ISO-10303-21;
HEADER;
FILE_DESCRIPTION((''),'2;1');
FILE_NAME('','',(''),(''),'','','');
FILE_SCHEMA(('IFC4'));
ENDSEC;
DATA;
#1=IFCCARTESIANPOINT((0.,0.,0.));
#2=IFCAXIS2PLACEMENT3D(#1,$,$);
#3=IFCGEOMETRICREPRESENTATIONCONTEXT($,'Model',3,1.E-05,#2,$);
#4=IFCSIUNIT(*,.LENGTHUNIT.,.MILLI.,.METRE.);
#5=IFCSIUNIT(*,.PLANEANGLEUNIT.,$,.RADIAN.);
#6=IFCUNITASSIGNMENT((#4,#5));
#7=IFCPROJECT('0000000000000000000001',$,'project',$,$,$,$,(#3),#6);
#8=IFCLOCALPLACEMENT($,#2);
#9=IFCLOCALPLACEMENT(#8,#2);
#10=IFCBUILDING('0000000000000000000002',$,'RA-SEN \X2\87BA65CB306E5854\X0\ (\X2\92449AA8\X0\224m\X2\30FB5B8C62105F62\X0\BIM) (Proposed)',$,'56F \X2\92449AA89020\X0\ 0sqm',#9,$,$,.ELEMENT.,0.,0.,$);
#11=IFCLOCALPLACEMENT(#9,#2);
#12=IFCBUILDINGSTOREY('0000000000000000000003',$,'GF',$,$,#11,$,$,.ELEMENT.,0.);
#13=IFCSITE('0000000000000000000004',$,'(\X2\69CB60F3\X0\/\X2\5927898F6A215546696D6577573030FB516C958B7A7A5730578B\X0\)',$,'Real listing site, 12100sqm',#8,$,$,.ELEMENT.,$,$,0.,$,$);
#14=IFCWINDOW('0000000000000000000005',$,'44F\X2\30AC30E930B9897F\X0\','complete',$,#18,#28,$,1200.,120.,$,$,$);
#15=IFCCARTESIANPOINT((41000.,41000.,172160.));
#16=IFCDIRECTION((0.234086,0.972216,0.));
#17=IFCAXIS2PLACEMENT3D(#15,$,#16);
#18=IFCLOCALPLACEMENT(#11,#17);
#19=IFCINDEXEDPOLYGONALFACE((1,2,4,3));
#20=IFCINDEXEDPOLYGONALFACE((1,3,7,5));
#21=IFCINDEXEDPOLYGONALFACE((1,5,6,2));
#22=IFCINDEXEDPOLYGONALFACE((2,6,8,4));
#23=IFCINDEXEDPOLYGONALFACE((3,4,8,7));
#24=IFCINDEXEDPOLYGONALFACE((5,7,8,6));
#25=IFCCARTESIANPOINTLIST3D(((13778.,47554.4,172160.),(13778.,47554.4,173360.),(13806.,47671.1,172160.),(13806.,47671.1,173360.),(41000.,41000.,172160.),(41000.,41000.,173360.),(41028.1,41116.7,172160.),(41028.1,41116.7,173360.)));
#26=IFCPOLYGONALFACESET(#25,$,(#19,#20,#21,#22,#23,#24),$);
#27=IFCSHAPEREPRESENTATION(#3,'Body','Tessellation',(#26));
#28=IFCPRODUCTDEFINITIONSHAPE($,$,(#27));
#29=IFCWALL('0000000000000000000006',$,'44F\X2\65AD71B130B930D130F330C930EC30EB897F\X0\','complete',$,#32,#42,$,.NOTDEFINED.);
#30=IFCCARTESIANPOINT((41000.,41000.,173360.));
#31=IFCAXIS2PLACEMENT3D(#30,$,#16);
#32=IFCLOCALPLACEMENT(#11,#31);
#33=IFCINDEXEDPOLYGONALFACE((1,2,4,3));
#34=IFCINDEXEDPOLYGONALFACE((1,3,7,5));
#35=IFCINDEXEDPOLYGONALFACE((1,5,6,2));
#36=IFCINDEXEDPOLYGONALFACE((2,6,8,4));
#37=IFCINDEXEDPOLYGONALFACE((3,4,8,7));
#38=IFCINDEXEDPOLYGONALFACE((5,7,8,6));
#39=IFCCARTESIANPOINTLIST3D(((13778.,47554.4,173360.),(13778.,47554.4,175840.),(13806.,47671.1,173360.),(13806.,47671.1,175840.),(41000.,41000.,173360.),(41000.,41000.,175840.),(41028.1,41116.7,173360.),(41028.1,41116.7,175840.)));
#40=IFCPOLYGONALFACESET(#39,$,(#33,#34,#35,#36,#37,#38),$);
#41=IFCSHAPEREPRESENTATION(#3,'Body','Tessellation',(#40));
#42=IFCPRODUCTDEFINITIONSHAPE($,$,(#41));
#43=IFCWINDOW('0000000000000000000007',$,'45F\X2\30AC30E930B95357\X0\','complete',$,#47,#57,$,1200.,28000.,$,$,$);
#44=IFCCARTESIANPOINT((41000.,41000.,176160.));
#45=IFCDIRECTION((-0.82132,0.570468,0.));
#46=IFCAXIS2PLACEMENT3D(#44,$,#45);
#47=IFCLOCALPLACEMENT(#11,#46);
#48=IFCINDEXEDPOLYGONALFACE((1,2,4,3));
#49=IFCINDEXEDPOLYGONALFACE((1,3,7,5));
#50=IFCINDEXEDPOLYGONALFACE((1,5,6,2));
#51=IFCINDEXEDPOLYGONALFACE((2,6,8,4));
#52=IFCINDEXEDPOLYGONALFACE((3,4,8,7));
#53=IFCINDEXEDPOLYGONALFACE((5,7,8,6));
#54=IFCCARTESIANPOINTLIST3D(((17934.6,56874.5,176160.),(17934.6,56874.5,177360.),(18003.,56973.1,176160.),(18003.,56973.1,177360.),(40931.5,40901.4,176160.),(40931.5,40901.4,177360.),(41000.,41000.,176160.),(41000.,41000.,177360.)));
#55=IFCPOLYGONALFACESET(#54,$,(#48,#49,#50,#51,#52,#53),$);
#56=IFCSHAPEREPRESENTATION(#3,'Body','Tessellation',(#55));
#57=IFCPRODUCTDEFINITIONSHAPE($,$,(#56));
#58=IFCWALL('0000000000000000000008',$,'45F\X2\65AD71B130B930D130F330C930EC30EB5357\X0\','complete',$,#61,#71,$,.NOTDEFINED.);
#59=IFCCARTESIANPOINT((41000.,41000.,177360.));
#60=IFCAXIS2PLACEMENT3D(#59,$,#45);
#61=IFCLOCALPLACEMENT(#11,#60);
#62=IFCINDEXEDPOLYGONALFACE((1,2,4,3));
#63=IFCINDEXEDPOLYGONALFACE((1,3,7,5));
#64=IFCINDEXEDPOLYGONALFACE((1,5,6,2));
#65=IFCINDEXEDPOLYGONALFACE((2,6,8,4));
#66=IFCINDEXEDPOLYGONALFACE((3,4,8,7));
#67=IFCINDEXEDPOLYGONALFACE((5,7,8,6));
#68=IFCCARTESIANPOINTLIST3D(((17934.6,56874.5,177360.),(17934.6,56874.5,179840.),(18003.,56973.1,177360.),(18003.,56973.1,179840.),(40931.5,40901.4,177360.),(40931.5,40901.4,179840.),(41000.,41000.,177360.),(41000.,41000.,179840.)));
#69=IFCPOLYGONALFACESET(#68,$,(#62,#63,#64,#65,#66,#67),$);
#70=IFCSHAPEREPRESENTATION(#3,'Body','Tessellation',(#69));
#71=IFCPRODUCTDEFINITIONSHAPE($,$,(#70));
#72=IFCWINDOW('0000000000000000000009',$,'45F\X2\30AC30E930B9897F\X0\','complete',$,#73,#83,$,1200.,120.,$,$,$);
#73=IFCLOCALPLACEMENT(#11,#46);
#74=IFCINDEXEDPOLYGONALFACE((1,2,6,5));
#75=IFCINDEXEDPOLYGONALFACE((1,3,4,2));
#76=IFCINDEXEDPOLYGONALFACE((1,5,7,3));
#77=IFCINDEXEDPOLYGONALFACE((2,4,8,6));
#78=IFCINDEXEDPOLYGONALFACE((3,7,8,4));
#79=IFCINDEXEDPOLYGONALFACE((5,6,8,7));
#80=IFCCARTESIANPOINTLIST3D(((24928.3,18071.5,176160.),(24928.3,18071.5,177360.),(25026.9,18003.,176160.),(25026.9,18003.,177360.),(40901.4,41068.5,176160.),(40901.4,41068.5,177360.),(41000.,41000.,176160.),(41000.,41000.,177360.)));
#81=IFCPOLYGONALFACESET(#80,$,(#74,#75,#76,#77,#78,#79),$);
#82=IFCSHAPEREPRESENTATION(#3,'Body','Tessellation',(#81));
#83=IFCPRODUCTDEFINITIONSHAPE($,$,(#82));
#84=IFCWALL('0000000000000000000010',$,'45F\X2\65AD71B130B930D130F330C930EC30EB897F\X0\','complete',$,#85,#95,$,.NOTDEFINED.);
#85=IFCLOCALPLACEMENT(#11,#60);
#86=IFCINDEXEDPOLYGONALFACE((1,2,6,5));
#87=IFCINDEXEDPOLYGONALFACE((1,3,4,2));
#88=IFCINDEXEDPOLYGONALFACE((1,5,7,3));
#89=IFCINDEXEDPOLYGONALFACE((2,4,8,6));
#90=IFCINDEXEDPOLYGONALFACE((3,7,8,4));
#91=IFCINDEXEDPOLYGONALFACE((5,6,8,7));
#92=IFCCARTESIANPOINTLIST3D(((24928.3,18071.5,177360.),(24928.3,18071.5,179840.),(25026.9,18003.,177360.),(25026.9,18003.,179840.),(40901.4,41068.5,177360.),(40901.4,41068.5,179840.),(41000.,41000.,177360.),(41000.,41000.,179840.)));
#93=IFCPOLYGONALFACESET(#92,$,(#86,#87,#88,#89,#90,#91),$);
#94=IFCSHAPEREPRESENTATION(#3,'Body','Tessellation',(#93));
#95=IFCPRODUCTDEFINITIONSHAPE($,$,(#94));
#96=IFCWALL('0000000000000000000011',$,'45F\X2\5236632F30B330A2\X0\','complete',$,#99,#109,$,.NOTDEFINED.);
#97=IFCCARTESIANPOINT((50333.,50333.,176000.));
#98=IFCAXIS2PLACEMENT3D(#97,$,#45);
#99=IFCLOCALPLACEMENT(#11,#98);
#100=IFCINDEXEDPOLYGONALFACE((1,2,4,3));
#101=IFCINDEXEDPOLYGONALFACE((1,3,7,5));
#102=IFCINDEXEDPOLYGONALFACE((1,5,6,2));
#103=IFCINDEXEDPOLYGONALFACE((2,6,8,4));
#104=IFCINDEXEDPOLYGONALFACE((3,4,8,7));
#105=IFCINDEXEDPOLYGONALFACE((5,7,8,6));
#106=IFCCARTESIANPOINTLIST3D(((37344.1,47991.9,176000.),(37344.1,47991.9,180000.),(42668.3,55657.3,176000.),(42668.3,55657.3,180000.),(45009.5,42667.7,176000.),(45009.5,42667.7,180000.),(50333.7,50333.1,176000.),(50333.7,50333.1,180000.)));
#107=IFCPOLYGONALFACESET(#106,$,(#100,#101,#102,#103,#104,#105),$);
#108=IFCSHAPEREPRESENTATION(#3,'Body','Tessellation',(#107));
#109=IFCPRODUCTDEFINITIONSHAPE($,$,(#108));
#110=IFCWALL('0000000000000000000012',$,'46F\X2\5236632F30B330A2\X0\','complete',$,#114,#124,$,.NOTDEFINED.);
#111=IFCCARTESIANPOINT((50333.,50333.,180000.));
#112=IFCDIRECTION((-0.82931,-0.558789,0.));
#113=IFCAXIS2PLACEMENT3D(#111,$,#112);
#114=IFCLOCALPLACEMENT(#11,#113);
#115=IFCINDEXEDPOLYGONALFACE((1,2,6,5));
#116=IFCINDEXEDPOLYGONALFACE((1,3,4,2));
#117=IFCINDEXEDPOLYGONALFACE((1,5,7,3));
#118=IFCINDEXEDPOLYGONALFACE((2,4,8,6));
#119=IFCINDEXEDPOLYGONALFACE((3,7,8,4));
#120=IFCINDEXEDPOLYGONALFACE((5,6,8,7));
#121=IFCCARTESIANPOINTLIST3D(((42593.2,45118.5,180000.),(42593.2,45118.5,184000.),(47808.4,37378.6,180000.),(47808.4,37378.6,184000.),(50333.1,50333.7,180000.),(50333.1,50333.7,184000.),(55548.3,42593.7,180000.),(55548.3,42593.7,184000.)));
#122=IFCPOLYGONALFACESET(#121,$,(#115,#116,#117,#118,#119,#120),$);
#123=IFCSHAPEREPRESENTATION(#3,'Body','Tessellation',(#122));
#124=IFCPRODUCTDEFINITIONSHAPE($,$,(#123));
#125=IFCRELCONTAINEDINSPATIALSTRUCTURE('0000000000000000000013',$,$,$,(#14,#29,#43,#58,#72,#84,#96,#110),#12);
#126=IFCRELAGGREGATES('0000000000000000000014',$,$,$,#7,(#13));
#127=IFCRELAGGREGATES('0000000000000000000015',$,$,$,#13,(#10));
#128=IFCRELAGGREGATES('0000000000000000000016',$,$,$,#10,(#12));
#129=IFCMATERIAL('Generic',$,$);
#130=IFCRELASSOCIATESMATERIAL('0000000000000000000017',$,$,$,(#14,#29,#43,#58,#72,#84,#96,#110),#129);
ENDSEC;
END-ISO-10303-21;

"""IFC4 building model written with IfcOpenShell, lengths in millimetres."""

from ifc_helpers import new_model, si_unit, frame, frame_2d, origin, place, context, project, spatial, rectangle, extrude, material, element, save


model = new_model("IFC4")

# Units and contexts
model_context = context("Model", 3, precision=1e-05, world=origin())
ifc_project = project(units=[si_unit("LENGTHUNIT", "METRE", prefix="MILLI"), si_unit("PLANEANGLEUNIT", "RADIAN")], contexts=[model_context])

# Site, building, storey
site_placement = place(None, origin())
site = spatial("IfcSite", under=ifc_project, at=site_placement, Name="(構想/大規模商業敷地・公開空地型)", ObjectType="Real listing site, 12100sqm", CompositionType="ELEMENT", RefElevation=0.0)
building_placement = place(site_placement, origin())
building = spatial("IfcBuilding", under=site, at=building_placement, Name="RA-SEN 螺旋の塔 (鉄骨224m・完成形BIM) (Proposed)", ObjectType="56F 鉄骨造 0sqm", CompositionType="ELEMENT", ElevationOfRefHeight=0.0, ElevationOfTerrain=0.0)
storey_placement = place(building_placement, origin())
storey = spatial("IfcBuildingStorey", under=building, at=storey_placement, Name="GF", CompositionType="ELEMENT", Elevation=0.0)

# Shared definitions
ifc_material = material(Name="Generic")

# Window
window_1_placement = place(storey_placement, frame((41000.0, 41000.0, 172160.0), x_axis=(0.234086, 0.972216, 0.0)))
element("IfcWindow", 1, at=window_1_placement, inside=storey, material=ifc_material, Name="44Fガラス西", Description="complete", OverallHeight=1200.0, OverallWidth=120.0, context=model_context, shape_type="SweptSolid", body=[
    extrude(rectangle(XDim=120.0, YDim=28000.0, at=frame_2d((60.0, 14000.0))), frame((41000.0, 41000.0, 172160.0), x_axis=(0.234086, 0.972216, 0.0)), (0.0, 0.0, 1.0), 1200.0),
])

# Wall
wall_1_placement = place(storey_placement, frame((41000.0, 41000.0, 173360.0), x_axis=(0.234086, 0.972216, 0.0)))
element("IfcWall", 2, at=wall_1_placement, inside=storey, material=ifc_material, Name="44F断熱スパンドレル西", Description="complete", PredefinedType="NOTDEFINED", context=model_context, shape_type="SweptSolid", body=[
    extrude(rectangle(XDim=120.0, YDim=28000.0, at=frame_2d((60.0, 14000.0))), frame((41000.0, 41000.0, 173360.0), x_axis=(0.234086, 0.972216, 0.0)), (0.0, 0.0, 1.0), 2480.0),
])

# Window
window_2_placement = place(storey_placement, frame((41000.0, 41000.0, 176160.0), x_axis=(-0.82132, 0.570468, 0.0)))
element("IfcWindow", 3, at=window_2_placement, inside=storey, material=ifc_material, Name="45Fガラス南", Description="complete", OverallHeight=1200.0, OverallWidth=28000.0, context=model_context, shape_type="SweptSolid", body=[
    extrude(rectangle(XDim=28000.0, YDim=120.0, at=frame_2d((14000.0, 60.0))), frame((41000.0, 41000.0, 176160.0), x_axis=(-0.82132, 0.570468, 0.0)), (0.0, 0.0, 1.0), 1200.0),
])

# Wall
wall_2_placement = place(storey_placement, frame((41000.0, 41000.0, 177360.0), x_axis=(-0.82132, 0.570468, 0.0)))
element("IfcWall", 4, at=wall_2_placement, inside=storey, material=ifc_material, Name="45F断熱スパンドレル南", Description="complete", PredefinedType="NOTDEFINED", context=model_context, shape_type="SweptSolid", body=[
    extrude(rectangle(XDim=28000.0, YDim=120.0, at=frame_2d((14000.0, 60.0))), frame((41000.0, 41000.0, 177360.0), x_axis=(-0.82132, 0.570468, 0.0)), (0.0, 0.0, 1.0), 2480.0),
])

# Window
window_3_placement = place(storey_placement, frame((41000.0, 41000.0, 176160.0), x_axis=(-0.82132, 0.570468, 0.0)))
element("IfcWindow", 5, at=window_3_placement, inside=storey, material=ifc_material, Name="45Fガラス西", Description="complete", OverallHeight=1200.0, OverallWidth=120.0, context=model_context, shape_type="SweptSolid", body=[
    extrude(rectangle(XDim=120.0, YDim=28000.0, at=frame_2d((60.0, 14000.0))), frame((41000.0, 41000.0, 176160.0), x_axis=(-0.82132, 0.570468, 0.0)), (0.0, 0.0, 1.0), 1200.0),
])

# Walls
wall_3_placement = place(storey_placement, frame((41000.0, 41000.0, 177360.0), x_axis=(-0.82132, 0.570468, 0.0)))
element("IfcWall", 6, at=wall_3_placement, inside=storey, material=ifc_material, Name="45F断熱スパンドレル西", Description="complete", PredefinedType="NOTDEFINED", context=model_context, shape_type="SweptSolid", body=[
    extrude(rectangle(XDim=120.0, YDim=28000.0, at=frame_2d((60.0, 14000.0))), frame((41000.0, 41000.0, 177360.0), x_axis=(-0.82132, 0.570468, 0.0)), (0.0, 0.0, 1.0), 2480.0),
])
wall_4_placement = place(storey_placement, frame((50333.0, 50333.0, 176000.0), x_axis=(-0.82132, 0.570468, 0.0)))
element("IfcWall", 7, at=wall_4_placement, inside=storey, material=ifc_material, Name="45F制振コア", Description="complete", PredefinedType="NOTDEFINED", context=model_context, shape_type="SweptSolid", body=[
    extrude(rectangle(XDim=9333.0, YDim=9333.0, at=frame_2d((4666.0, 4666.0))), frame((50333.0, 50333.0, 176000.0), x_axis=(-0.82132, 0.570468, 0.0)), (0.0, 0.0, 1.0), 4000.0),
])
wall_5_placement = place(storey_placement, frame((50333.0, 50333.0, 180000.0), x_axis=(-0.82931, -0.558789, 0.0)))
element("IfcWall", 8, at=wall_5_placement, inside=storey, material=ifc_material, Name="46F制振コア", Description="complete", PredefinedType="NOTDEFINED", context=model_context, shape_type="SweptSolid", body=[
    extrude(rectangle(XDim=9333.0, YDim=9333.0, at=frame_2d((4666.0, 4666.0))), frame((50333.0, 50333.0, 180000.0), x_axis=(-0.82931, -0.558789, 0.0)), (0.0, 0.0, 1.0), 4000.0),
])

save(model, "model.ifc")
